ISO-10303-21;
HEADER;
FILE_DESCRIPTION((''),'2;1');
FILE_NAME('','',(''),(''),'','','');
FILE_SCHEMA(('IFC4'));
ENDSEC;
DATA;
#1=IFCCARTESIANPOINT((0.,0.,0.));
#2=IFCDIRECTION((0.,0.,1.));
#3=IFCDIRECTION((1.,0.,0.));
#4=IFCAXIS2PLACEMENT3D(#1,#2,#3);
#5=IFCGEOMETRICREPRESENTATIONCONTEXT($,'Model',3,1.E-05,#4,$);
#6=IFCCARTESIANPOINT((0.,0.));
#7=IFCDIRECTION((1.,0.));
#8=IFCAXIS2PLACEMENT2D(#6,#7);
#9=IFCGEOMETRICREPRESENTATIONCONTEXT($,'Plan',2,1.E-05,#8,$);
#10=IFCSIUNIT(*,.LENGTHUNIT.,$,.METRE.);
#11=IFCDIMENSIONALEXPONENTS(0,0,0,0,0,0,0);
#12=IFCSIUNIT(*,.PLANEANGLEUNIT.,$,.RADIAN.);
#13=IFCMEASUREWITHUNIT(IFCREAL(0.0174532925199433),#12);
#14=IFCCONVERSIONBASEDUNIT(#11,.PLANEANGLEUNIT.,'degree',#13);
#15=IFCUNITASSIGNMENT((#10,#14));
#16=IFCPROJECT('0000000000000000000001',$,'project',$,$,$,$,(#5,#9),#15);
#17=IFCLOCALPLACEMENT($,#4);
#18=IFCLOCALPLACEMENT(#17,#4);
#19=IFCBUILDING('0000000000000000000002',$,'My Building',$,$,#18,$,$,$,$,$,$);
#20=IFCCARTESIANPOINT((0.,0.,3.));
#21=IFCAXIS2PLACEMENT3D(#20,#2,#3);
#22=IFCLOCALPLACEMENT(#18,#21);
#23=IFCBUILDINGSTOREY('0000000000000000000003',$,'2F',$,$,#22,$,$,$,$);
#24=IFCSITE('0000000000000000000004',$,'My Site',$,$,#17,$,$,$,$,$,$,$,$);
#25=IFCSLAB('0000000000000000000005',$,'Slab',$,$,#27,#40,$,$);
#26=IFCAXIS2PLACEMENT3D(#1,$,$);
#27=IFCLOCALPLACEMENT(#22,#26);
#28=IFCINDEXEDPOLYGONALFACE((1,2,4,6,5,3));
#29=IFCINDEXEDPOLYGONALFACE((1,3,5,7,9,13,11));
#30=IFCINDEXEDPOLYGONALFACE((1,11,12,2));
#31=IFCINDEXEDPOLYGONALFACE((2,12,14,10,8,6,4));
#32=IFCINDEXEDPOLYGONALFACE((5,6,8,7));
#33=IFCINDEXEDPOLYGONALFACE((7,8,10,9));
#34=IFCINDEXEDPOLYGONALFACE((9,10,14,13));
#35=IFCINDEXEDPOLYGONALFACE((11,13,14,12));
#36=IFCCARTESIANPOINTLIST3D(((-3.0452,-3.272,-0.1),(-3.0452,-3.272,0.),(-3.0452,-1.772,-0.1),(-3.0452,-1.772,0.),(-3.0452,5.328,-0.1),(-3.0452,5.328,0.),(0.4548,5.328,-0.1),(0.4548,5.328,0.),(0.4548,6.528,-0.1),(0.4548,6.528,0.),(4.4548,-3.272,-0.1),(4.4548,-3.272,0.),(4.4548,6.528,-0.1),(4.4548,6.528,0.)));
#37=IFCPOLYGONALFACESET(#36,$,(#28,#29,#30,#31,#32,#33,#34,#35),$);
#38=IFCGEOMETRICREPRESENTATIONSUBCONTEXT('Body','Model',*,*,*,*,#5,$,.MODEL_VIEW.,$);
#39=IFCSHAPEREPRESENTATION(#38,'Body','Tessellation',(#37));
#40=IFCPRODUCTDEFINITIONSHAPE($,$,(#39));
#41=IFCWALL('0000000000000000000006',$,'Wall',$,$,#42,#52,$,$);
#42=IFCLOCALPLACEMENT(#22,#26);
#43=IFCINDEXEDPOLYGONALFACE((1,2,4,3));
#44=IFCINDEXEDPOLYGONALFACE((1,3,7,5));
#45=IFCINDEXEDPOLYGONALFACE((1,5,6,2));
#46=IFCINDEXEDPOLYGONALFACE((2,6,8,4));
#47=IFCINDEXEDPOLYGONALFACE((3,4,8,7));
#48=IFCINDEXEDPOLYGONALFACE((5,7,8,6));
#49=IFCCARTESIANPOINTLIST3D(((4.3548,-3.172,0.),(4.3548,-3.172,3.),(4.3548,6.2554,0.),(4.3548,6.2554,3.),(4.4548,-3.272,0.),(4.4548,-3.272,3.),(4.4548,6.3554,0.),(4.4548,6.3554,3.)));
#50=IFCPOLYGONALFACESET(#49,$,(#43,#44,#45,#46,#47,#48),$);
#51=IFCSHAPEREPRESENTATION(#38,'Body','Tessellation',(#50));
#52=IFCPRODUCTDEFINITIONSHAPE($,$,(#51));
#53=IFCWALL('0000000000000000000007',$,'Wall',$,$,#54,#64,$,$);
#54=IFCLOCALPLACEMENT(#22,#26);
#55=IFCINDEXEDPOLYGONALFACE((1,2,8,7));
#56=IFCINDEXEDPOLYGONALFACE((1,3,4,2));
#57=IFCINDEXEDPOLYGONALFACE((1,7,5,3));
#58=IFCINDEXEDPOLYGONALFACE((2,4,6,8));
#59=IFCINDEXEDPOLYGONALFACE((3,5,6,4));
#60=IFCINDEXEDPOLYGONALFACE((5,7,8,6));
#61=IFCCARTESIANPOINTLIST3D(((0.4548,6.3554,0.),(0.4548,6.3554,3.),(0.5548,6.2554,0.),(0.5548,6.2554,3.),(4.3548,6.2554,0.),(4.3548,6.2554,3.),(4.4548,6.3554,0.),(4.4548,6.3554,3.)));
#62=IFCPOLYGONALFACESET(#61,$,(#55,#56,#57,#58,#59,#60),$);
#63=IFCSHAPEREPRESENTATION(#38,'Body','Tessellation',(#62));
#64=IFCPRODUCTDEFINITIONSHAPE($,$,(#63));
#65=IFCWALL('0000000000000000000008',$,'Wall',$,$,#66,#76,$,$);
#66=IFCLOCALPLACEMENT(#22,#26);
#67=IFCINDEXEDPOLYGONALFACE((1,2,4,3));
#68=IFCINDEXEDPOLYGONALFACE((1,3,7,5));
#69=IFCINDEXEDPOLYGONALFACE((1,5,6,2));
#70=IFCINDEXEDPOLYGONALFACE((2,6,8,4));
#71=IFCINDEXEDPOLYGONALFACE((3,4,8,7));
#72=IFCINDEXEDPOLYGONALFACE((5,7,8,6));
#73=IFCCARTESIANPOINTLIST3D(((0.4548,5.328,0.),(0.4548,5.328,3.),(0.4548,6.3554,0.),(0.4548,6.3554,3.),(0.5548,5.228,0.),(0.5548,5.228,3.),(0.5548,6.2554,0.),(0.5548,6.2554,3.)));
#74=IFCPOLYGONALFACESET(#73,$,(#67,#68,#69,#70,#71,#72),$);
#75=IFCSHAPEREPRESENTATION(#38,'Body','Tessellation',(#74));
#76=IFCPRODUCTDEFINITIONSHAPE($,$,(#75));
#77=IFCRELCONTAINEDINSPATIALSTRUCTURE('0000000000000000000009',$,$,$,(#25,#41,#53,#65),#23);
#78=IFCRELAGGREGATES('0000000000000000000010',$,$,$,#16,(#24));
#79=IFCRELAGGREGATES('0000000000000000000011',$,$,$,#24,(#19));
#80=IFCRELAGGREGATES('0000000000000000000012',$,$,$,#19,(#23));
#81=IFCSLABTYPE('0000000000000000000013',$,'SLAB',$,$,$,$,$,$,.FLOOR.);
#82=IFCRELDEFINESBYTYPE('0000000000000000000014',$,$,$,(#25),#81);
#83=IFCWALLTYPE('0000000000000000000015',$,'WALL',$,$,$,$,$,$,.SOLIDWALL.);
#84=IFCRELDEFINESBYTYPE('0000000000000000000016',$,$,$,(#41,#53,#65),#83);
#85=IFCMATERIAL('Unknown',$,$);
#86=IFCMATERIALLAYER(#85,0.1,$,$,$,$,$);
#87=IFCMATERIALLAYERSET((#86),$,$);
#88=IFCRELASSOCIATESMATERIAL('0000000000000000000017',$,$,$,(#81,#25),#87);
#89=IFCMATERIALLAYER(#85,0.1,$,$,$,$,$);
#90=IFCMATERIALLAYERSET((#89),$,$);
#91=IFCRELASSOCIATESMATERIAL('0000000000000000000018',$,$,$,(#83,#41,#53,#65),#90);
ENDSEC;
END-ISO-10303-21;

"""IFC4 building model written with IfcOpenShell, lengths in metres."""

from ifc_helpers import new_model, entity, si_unit, converted_unit, frame, origin_with_axes, origin_2d_with_axis, place, context, subcontext, project, spatial, line, indexed_curve, outline, extrude, material, layer, layer_set, layer_usage, type_object, element, save


model = new_model("IFC4")

# Units and contexts
model_context = context("Model", 3, precision=1e-05, world=origin_with_axes())
plan_context = context("Plan", 2, precision=1e-05, world=origin_2d_with_axis())
body_context_1 = subcontext(model_context, "Body", "Model", "MODEL_VIEW")
ifc_project = project(units=[si_unit("LENGTHUNIT", "METRE"), converted_unit("PLANEANGLEUNIT", "degree", entity("IfcReal", 0.0174532925199433), si_unit("PLANEANGLEUNIT", "RADIAN"), dimensions=[0, 0, 0, 0, 0, 0, 0])], contexts=[model_context, plan_context])

# Site, building, storey
site_placement = place(None, origin_with_axes())
site = spatial("IfcSite", under=ifc_project, at=site_placement, Name="My Site")
building_placement = place(site_placement, origin_with_axes())
building = spatial("IfcBuilding", under=site, at=building_placement, Name="My Building")
storey_placement = place(building_placement, frame((0.0, 0.0, 3.0), z_axis=(0.0, 0.0, 1.0), x_axis=(1.0, 0.0, 0.0)))
storey = spatial("IfcBuildingStorey", under=building, at=storey_placement, Name="2F")

# Slab
ifc_material = material(Name="Unknown")
ifc_layer_1 = layer(ifc_material, 0.1)
ifc_layer_set_1 = layer_set([ifc_layer_1])
ifc_layer_usage_1 = layer_usage(ifc_layer_set_1, "AXIS3", "POSITIVE", -0.1)
slab_type = type_object("IfcSlabType", Name="SLAB", PredefinedType="FLOOR", material=ifc_layer_set_1)
slab_placement = place(storey_placement, frame((4.4548, -3.272, 0.0), z_axis=(0.0, 0.0, 1.0), x_axis=(1.0, 0.0, 0.0)))
element("IfcSlab", 1, at=slab_placement, inside=storey, type_object=slab_type, material=ifc_layer_usage_1, Name="Slab", context=body_context_1, shape_type="SweptSolid", body=[
    extrude(outline(indexed_curve([(0.0, 0.0), (0.0, 9.8), (-4.0, 9.8), (-4.0, 8.6), (-7.5, 8.6), (-7.5, 1.5), (-7.5, 0.0), (0.0, 0.0)])), frame((0.0, 0.0, -0.1), z_axis=(0.0, 0.0, 1.0), x_axis=(1.0, 0.0, 0.0)), (0.0, 0.0, 1.0), 0.1),
])

# Walls
ifc_layer_2 = layer(ifc_material, 0.1)
ifc_layer_set_2 = layer_set([ifc_layer_2])
ifc_layer_usage_2 = layer_usage(ifc_layer_set_2, "AXIS2", "POSITIVE", 0.0)
wall_type_1 = type_object("IfcWallType", Name="WALL", PredefinedType="SOLIDWALL", material=ifc_layer_set_2)
wall_1_placement = place(storey_placement, frame((4.4548, -3.272, 0.0), z_axis=(0.0, 0.0, 1.0), x_axis=(0.0, 1.0, 0.0)))
element("IfcWall", 2, at=wall_1_placement, inside=storey, type_object=wall_type_1, material=ifc_layer_usage_2, Name="Wall", context=body_context_1, shape_type="SweptSolid", body=[
    extrude(outline(indexed_curve([(0.0, 0.0), (0.1, 0.1), (9.5273, 0.1), (9.6273, 0.0)], segments=[line(1, 2, 3, 4, 1)])), origin_with_axes(), (0.0, 0.0, 1.0), 3.0),
])
ifc_layer_usage_3 = layer_usage(ifc_layer_set_2, "AXIS2", "POSITIVE", 0.0)
wall_2_placement = place(storey_placement, frame((4.4548, 6.3554, 0.0), z_axis=(0.0, 0.0, 1.0), x_axis=(-1.0, 0.0, 0.0)))
element("IfcWall", 3, at=wall_2_placement, inside=storey, type_object=wall_type_1, material=ifc_layer_usage_3, Name="Wall", context=body_context_1, shape_type="SweptSolid", body=[
    extrude(outline(indexed_curve([(0.0, 0.0), (0.1, 0.1), (3.9, 0.1), (4.0, 0.0)], segments=[line(1, 2, 3, 4, 1)])), origin_with_axes(), (0.0, 0.0, 1.0), 3.0),
])
ifc_layer_usage_4 = layer_usage(ifc_layer_set_2, "AXIS2", "POSITIVE", 0.0)
wall_3_placement = place(storey_placement, frame((0.4548, 6.3554, 0.0), z_axis=(0.0, 0.0, 1.0), x_axis=(0.0, -1.0, 0.0)))
element("IfcWall", 4, at=wall_3_placement, inside=storey, type_object=wall_type_1, material=ifc_layer_usage_4, Name="Wall", context=body_context_1, shape_type="SweptSolid", body=[
    extrude(outline(indexed_curve([(0.0, 0.0), (0.1, 0.1), (1.1273, 0.1), (1.0273, 0.0)], segments=[line(1, 2, 3, 4, 1)])), origin_with_axes(), (0.0, 0.0, 1.0), 3.0),
])

save(model, "model.ifc")
